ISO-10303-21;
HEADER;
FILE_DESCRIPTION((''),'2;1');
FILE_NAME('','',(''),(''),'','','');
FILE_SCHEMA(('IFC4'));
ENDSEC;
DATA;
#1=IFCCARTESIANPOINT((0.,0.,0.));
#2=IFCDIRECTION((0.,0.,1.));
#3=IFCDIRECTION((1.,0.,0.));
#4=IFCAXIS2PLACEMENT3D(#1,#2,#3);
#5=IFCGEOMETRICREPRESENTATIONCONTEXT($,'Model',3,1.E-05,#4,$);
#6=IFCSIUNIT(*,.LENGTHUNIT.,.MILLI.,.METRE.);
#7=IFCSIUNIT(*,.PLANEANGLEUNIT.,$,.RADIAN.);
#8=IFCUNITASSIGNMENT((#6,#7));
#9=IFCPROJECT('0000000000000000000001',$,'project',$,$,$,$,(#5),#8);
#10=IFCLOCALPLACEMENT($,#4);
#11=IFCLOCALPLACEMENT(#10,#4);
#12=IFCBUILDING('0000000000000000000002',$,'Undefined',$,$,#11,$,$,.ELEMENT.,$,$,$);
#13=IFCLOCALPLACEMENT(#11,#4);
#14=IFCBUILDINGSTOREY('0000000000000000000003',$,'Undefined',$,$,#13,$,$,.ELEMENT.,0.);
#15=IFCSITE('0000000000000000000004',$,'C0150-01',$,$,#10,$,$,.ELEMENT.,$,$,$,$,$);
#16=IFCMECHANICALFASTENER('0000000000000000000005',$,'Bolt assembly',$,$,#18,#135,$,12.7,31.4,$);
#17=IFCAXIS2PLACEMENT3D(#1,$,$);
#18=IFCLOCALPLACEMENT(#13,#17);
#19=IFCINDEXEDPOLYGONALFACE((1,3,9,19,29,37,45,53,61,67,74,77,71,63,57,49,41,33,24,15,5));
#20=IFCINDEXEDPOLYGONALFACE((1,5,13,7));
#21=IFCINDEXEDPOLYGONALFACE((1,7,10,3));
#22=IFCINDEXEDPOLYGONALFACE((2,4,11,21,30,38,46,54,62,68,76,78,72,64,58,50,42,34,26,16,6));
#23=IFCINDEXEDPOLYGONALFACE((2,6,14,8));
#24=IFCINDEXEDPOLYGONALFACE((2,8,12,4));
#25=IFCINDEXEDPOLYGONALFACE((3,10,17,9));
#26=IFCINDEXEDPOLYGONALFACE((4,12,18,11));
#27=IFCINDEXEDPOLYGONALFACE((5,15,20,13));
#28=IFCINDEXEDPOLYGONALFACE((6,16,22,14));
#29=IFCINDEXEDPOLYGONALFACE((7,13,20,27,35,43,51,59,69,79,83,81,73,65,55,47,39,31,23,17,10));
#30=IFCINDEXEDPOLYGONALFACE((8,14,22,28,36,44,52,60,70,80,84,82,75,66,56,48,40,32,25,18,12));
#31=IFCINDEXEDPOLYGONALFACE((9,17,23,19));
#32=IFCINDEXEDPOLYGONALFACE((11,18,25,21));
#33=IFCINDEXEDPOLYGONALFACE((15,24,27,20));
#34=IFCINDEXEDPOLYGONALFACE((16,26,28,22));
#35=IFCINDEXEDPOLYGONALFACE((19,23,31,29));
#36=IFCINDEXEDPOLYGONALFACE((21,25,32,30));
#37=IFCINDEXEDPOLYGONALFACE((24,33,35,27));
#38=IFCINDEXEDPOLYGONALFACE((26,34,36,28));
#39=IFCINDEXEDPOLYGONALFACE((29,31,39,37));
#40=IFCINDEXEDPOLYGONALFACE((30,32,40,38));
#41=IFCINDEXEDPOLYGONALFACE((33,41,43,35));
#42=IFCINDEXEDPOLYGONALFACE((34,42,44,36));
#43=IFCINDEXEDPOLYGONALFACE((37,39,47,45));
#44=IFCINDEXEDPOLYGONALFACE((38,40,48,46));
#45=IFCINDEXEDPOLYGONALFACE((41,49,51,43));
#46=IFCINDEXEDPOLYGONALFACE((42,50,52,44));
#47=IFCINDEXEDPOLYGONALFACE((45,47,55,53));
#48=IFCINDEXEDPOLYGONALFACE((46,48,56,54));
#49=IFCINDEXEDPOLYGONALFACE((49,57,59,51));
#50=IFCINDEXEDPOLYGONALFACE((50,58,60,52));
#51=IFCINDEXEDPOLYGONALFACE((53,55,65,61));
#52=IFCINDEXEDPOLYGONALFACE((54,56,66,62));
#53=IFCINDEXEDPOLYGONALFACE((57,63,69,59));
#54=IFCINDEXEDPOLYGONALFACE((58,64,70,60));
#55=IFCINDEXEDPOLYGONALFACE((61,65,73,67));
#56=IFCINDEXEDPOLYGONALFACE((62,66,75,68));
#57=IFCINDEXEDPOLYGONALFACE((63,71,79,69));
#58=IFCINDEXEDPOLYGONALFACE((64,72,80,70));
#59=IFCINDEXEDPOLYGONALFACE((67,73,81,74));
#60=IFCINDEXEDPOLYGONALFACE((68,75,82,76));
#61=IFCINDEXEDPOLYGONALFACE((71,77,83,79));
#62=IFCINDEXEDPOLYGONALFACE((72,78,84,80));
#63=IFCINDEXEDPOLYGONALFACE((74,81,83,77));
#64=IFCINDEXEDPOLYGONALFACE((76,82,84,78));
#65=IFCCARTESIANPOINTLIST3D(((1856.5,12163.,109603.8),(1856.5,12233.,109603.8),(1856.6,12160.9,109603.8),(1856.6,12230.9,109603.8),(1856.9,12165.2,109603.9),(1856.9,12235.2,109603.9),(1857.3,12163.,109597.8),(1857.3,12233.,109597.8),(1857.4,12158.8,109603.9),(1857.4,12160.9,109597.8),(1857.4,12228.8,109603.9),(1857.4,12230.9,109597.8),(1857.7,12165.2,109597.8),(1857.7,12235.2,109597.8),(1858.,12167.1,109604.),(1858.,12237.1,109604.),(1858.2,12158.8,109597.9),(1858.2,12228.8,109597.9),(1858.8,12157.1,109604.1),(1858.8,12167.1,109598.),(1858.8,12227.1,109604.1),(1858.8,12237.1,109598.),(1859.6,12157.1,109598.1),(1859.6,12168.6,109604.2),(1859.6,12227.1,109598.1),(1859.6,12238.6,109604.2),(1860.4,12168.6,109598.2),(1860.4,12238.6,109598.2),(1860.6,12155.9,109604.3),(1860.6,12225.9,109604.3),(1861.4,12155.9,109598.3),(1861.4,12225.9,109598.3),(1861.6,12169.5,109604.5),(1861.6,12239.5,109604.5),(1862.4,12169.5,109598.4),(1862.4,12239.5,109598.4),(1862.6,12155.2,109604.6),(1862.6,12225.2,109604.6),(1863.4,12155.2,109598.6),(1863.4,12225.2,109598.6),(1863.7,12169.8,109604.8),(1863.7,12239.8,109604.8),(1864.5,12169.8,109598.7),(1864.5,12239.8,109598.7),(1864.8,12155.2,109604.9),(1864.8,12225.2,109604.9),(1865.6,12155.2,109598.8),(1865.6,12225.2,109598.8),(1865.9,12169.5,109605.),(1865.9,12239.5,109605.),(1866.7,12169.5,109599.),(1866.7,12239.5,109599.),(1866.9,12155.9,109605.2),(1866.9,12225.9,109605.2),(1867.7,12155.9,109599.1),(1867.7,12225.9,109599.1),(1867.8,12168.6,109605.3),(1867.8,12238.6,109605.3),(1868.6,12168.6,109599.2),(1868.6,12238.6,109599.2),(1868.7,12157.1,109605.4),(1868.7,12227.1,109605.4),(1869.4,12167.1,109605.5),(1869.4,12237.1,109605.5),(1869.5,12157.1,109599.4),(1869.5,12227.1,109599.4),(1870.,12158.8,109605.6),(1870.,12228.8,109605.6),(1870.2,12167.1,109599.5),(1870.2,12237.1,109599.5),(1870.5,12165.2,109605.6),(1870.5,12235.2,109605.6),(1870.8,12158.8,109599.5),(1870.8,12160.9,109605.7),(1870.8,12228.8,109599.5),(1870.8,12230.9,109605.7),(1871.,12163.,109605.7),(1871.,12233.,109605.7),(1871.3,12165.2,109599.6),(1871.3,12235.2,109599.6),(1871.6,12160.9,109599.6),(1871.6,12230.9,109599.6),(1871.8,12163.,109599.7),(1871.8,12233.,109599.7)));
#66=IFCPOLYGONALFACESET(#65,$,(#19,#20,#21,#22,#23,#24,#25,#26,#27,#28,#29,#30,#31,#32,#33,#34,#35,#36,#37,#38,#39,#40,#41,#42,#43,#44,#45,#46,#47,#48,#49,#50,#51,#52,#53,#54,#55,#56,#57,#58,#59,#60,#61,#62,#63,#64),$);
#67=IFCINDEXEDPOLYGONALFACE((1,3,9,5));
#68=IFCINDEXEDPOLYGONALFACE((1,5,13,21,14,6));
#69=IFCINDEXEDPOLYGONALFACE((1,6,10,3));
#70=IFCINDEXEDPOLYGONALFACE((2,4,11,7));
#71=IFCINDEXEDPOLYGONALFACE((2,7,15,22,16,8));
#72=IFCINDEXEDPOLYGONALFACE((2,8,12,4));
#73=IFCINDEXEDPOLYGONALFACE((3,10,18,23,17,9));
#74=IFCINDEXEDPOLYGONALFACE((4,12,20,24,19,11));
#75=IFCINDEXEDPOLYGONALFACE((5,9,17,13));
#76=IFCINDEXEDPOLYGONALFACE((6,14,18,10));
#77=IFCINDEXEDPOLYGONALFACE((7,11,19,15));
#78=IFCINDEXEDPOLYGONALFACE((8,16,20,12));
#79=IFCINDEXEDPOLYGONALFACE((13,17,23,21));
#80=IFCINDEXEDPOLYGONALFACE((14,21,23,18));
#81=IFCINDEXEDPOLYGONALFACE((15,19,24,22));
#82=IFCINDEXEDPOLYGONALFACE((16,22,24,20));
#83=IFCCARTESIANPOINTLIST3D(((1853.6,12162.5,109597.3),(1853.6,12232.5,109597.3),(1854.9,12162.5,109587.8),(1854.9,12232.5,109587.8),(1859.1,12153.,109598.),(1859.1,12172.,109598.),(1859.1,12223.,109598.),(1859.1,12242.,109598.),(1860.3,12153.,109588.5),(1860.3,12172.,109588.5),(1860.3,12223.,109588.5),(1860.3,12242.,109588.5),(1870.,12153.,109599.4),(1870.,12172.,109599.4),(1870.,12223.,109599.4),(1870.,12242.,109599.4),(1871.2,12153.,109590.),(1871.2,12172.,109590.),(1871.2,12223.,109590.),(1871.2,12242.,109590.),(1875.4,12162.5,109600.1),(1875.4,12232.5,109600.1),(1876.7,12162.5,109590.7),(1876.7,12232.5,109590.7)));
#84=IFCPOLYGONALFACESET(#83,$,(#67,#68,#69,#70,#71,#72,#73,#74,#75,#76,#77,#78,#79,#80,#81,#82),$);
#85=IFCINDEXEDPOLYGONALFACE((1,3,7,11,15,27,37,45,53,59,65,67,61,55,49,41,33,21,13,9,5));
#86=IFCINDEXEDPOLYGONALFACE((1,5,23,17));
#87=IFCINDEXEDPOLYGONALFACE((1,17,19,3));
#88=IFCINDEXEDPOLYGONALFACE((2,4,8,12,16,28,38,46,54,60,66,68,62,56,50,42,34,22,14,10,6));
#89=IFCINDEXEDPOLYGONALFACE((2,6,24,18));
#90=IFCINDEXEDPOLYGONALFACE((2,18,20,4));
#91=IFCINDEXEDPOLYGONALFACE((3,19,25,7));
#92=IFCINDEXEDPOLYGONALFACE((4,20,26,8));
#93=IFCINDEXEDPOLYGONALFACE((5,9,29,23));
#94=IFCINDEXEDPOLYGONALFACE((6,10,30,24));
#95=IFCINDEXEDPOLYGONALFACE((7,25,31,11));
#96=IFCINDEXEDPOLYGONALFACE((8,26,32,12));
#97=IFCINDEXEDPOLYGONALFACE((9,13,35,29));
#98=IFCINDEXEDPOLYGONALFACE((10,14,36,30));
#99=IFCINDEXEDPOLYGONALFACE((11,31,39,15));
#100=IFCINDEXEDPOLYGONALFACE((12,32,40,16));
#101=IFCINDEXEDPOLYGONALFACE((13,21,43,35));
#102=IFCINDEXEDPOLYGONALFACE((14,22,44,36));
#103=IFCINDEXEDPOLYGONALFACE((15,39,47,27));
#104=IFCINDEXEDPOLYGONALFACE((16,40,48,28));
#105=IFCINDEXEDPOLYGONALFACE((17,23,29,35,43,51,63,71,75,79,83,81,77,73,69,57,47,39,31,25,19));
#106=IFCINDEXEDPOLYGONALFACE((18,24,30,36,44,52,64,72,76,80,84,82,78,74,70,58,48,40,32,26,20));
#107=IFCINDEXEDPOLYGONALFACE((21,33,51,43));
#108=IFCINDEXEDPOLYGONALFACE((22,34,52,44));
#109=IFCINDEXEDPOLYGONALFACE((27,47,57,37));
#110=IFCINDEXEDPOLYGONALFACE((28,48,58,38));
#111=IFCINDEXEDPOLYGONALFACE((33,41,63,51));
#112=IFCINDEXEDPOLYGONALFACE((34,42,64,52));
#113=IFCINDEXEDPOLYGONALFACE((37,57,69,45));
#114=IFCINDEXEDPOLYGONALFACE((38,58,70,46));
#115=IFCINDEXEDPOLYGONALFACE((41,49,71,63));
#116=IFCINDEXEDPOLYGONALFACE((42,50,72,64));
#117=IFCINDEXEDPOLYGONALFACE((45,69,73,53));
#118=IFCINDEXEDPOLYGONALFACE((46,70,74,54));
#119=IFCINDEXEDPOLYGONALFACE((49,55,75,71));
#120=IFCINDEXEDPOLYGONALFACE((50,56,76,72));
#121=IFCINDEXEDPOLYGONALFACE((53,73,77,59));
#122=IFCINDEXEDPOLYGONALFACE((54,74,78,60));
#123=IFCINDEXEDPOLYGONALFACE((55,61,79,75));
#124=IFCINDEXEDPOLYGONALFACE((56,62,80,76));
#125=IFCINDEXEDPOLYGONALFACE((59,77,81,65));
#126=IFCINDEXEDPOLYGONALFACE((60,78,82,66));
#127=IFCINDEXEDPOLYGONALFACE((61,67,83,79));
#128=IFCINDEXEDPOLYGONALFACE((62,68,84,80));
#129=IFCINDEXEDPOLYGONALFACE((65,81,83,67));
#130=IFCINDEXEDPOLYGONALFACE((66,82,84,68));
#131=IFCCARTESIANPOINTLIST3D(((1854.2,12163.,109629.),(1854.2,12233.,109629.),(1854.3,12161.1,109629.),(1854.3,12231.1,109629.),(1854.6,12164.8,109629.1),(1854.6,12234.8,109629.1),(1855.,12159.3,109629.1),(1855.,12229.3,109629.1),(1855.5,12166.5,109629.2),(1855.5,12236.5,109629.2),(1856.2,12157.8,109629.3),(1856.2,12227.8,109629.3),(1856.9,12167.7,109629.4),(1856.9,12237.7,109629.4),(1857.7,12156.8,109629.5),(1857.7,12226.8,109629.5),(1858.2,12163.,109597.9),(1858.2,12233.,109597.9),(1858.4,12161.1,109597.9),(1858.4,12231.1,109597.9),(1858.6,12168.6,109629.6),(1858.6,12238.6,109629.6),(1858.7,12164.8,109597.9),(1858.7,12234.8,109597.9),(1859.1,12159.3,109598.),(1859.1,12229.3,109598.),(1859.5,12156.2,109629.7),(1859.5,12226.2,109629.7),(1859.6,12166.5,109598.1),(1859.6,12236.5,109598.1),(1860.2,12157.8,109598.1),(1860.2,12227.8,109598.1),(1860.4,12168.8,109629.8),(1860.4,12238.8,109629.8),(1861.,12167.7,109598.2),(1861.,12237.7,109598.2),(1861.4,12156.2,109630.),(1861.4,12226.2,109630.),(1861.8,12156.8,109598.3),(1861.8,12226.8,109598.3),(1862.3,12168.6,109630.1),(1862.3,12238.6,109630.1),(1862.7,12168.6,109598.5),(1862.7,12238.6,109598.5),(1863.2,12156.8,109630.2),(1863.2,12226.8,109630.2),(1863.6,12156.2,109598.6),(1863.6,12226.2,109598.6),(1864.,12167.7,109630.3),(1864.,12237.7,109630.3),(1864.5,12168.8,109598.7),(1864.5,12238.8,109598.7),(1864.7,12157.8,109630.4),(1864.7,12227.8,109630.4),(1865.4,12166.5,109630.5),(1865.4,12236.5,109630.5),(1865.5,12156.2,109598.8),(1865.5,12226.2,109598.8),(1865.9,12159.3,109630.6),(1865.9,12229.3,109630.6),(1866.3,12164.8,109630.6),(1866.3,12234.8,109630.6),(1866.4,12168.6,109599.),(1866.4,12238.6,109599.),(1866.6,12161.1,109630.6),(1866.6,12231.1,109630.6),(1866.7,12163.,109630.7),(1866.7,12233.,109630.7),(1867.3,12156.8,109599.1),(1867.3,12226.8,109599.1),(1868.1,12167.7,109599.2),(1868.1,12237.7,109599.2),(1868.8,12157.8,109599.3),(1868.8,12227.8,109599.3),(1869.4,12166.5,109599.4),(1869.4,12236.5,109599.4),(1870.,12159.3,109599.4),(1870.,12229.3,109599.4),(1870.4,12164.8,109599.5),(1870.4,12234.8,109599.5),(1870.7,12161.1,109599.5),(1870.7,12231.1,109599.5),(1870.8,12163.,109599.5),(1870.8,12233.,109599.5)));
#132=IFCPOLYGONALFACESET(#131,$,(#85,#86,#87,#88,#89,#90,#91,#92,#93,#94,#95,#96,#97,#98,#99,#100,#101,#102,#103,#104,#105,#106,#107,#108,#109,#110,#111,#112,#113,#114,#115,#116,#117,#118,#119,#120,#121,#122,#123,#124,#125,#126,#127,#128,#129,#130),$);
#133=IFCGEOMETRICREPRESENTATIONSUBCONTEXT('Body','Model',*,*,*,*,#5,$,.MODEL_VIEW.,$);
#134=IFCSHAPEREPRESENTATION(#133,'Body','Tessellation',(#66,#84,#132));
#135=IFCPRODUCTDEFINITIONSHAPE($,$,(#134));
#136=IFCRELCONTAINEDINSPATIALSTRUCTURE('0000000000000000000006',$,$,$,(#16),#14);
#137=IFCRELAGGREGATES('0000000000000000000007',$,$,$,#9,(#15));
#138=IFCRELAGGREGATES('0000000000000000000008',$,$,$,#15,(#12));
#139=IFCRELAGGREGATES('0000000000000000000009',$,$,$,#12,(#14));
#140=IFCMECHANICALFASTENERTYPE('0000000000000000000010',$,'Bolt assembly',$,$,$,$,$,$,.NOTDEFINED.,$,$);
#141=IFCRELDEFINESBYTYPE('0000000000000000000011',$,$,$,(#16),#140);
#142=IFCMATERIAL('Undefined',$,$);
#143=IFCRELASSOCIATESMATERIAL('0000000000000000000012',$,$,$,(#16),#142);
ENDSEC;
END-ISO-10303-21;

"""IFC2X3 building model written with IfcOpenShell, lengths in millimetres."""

from ifc_helpers import new_model, si_unit, frame, origin_with_axes, origin_2d_with_axis, place, context, subcontext, project, spatial, polyline, circle, outline, extrude, source, transform, mapped, material, type_object, element, save


model = new_model("IFC2X3")

# Units and contexts
model_context = context("Model", 3, precision=1e-05, world=origin_with_axes())
body_context = subcontext(model_context, "Body", "Model", "MODEL_VIEW")
ifc_project = project(units=[si_unit("LENGTHUNIT", "METRE", prefix="MILLI"), si_unit("PLANEANGLEUNIT", "RADIAN")], contexts=[model_context])

# Site, building, storey
site_placement = place(None, origin_with_axes())
site = spatial("IfcSite", under=ifc_project, at=site_placement, Name="C0150-01", CompositionType="ELEMENT")
building_placement = place(site_placement, origin_with_axes())
building = spatial("IfcBuilding", under=site, at=building_placement, Name="Undefined", CompositionType="ELEMENT")
storey_placement = place(building_placement, origin_with_axes())
storey = spatial("IfcBuildingStorey", under=building, at=storey_placement, Name="Undefined", CompositionType="ELEMENT", Elevation=0.0)

# Mechanical fastener
ifc_material_1 = material(Name="Undefined")
mechanical_fastener_type = type_object("IfcMechanicalFastenerType", Name="Bolt assembly")
shared_shape_1 = source(origin_with_axes(), body_context, "Body", "SweptSolid", [
    extrude(circle(Radius=7.3, at=origin_2d_with_axis()), frame((0.0, -2.0, 0.0), z_axis=(0.0, 1.0, 0.0), x_axis=(1.0, 0.0, 0.0)), (0.0, 0.0, 1.0), 6.1),
    extrude(outline(polyline([(9.5, -5.5), (9.5, 5.5), (0.0, 11.0), (-9.5, 5.5), (-9.5, -5.5), (0.0, -11.0), (9.5, -5.5)])), frame((0.0, -11.5, 0.0), z_axis=(0.0, 1.0, 0.0), x_axis=(1.0, 0.0, 0.0)), (0.0, 0.0, 1.0), 9.5),
    extrude(circle(Radius=6.3, at=origin_2d_with_axis()), frame((0.0, -2.0, 0.0), z_axis=(0.0, 1.0, 0.0), x_axis=(1.0, 0.0, 0.0)), (0.0, 0.0, 1.0), 31.4),
])
for number, where, z_axis, x_axis, name in (
    (1, (1864.3, 12162.5, 109600.7), (0.991507, 0.0, 0.130054), (0.0, 1.0, 0.0), "Bolt assembly"),
):
    element("IfcMechanicalFastener", number, at=place(storey_placement, frame(where, z_axis=z_axis, x_axis=x_axis)), inside=storey, type_object=mechanical_fastener_type, material=ifc_material_1, Name=name, NominalDiameter=12.7, NominalLength=31.4, context=body_context, shape_type="MappedRepresentation", body=[
        mapped(shared_shape_1, transform((0.0, 0.0, 0.0))),
        mapped(shared_shape_1, transform((70.0, 0.0, 0.0))),
    ])

save(model, "model.ifc")
